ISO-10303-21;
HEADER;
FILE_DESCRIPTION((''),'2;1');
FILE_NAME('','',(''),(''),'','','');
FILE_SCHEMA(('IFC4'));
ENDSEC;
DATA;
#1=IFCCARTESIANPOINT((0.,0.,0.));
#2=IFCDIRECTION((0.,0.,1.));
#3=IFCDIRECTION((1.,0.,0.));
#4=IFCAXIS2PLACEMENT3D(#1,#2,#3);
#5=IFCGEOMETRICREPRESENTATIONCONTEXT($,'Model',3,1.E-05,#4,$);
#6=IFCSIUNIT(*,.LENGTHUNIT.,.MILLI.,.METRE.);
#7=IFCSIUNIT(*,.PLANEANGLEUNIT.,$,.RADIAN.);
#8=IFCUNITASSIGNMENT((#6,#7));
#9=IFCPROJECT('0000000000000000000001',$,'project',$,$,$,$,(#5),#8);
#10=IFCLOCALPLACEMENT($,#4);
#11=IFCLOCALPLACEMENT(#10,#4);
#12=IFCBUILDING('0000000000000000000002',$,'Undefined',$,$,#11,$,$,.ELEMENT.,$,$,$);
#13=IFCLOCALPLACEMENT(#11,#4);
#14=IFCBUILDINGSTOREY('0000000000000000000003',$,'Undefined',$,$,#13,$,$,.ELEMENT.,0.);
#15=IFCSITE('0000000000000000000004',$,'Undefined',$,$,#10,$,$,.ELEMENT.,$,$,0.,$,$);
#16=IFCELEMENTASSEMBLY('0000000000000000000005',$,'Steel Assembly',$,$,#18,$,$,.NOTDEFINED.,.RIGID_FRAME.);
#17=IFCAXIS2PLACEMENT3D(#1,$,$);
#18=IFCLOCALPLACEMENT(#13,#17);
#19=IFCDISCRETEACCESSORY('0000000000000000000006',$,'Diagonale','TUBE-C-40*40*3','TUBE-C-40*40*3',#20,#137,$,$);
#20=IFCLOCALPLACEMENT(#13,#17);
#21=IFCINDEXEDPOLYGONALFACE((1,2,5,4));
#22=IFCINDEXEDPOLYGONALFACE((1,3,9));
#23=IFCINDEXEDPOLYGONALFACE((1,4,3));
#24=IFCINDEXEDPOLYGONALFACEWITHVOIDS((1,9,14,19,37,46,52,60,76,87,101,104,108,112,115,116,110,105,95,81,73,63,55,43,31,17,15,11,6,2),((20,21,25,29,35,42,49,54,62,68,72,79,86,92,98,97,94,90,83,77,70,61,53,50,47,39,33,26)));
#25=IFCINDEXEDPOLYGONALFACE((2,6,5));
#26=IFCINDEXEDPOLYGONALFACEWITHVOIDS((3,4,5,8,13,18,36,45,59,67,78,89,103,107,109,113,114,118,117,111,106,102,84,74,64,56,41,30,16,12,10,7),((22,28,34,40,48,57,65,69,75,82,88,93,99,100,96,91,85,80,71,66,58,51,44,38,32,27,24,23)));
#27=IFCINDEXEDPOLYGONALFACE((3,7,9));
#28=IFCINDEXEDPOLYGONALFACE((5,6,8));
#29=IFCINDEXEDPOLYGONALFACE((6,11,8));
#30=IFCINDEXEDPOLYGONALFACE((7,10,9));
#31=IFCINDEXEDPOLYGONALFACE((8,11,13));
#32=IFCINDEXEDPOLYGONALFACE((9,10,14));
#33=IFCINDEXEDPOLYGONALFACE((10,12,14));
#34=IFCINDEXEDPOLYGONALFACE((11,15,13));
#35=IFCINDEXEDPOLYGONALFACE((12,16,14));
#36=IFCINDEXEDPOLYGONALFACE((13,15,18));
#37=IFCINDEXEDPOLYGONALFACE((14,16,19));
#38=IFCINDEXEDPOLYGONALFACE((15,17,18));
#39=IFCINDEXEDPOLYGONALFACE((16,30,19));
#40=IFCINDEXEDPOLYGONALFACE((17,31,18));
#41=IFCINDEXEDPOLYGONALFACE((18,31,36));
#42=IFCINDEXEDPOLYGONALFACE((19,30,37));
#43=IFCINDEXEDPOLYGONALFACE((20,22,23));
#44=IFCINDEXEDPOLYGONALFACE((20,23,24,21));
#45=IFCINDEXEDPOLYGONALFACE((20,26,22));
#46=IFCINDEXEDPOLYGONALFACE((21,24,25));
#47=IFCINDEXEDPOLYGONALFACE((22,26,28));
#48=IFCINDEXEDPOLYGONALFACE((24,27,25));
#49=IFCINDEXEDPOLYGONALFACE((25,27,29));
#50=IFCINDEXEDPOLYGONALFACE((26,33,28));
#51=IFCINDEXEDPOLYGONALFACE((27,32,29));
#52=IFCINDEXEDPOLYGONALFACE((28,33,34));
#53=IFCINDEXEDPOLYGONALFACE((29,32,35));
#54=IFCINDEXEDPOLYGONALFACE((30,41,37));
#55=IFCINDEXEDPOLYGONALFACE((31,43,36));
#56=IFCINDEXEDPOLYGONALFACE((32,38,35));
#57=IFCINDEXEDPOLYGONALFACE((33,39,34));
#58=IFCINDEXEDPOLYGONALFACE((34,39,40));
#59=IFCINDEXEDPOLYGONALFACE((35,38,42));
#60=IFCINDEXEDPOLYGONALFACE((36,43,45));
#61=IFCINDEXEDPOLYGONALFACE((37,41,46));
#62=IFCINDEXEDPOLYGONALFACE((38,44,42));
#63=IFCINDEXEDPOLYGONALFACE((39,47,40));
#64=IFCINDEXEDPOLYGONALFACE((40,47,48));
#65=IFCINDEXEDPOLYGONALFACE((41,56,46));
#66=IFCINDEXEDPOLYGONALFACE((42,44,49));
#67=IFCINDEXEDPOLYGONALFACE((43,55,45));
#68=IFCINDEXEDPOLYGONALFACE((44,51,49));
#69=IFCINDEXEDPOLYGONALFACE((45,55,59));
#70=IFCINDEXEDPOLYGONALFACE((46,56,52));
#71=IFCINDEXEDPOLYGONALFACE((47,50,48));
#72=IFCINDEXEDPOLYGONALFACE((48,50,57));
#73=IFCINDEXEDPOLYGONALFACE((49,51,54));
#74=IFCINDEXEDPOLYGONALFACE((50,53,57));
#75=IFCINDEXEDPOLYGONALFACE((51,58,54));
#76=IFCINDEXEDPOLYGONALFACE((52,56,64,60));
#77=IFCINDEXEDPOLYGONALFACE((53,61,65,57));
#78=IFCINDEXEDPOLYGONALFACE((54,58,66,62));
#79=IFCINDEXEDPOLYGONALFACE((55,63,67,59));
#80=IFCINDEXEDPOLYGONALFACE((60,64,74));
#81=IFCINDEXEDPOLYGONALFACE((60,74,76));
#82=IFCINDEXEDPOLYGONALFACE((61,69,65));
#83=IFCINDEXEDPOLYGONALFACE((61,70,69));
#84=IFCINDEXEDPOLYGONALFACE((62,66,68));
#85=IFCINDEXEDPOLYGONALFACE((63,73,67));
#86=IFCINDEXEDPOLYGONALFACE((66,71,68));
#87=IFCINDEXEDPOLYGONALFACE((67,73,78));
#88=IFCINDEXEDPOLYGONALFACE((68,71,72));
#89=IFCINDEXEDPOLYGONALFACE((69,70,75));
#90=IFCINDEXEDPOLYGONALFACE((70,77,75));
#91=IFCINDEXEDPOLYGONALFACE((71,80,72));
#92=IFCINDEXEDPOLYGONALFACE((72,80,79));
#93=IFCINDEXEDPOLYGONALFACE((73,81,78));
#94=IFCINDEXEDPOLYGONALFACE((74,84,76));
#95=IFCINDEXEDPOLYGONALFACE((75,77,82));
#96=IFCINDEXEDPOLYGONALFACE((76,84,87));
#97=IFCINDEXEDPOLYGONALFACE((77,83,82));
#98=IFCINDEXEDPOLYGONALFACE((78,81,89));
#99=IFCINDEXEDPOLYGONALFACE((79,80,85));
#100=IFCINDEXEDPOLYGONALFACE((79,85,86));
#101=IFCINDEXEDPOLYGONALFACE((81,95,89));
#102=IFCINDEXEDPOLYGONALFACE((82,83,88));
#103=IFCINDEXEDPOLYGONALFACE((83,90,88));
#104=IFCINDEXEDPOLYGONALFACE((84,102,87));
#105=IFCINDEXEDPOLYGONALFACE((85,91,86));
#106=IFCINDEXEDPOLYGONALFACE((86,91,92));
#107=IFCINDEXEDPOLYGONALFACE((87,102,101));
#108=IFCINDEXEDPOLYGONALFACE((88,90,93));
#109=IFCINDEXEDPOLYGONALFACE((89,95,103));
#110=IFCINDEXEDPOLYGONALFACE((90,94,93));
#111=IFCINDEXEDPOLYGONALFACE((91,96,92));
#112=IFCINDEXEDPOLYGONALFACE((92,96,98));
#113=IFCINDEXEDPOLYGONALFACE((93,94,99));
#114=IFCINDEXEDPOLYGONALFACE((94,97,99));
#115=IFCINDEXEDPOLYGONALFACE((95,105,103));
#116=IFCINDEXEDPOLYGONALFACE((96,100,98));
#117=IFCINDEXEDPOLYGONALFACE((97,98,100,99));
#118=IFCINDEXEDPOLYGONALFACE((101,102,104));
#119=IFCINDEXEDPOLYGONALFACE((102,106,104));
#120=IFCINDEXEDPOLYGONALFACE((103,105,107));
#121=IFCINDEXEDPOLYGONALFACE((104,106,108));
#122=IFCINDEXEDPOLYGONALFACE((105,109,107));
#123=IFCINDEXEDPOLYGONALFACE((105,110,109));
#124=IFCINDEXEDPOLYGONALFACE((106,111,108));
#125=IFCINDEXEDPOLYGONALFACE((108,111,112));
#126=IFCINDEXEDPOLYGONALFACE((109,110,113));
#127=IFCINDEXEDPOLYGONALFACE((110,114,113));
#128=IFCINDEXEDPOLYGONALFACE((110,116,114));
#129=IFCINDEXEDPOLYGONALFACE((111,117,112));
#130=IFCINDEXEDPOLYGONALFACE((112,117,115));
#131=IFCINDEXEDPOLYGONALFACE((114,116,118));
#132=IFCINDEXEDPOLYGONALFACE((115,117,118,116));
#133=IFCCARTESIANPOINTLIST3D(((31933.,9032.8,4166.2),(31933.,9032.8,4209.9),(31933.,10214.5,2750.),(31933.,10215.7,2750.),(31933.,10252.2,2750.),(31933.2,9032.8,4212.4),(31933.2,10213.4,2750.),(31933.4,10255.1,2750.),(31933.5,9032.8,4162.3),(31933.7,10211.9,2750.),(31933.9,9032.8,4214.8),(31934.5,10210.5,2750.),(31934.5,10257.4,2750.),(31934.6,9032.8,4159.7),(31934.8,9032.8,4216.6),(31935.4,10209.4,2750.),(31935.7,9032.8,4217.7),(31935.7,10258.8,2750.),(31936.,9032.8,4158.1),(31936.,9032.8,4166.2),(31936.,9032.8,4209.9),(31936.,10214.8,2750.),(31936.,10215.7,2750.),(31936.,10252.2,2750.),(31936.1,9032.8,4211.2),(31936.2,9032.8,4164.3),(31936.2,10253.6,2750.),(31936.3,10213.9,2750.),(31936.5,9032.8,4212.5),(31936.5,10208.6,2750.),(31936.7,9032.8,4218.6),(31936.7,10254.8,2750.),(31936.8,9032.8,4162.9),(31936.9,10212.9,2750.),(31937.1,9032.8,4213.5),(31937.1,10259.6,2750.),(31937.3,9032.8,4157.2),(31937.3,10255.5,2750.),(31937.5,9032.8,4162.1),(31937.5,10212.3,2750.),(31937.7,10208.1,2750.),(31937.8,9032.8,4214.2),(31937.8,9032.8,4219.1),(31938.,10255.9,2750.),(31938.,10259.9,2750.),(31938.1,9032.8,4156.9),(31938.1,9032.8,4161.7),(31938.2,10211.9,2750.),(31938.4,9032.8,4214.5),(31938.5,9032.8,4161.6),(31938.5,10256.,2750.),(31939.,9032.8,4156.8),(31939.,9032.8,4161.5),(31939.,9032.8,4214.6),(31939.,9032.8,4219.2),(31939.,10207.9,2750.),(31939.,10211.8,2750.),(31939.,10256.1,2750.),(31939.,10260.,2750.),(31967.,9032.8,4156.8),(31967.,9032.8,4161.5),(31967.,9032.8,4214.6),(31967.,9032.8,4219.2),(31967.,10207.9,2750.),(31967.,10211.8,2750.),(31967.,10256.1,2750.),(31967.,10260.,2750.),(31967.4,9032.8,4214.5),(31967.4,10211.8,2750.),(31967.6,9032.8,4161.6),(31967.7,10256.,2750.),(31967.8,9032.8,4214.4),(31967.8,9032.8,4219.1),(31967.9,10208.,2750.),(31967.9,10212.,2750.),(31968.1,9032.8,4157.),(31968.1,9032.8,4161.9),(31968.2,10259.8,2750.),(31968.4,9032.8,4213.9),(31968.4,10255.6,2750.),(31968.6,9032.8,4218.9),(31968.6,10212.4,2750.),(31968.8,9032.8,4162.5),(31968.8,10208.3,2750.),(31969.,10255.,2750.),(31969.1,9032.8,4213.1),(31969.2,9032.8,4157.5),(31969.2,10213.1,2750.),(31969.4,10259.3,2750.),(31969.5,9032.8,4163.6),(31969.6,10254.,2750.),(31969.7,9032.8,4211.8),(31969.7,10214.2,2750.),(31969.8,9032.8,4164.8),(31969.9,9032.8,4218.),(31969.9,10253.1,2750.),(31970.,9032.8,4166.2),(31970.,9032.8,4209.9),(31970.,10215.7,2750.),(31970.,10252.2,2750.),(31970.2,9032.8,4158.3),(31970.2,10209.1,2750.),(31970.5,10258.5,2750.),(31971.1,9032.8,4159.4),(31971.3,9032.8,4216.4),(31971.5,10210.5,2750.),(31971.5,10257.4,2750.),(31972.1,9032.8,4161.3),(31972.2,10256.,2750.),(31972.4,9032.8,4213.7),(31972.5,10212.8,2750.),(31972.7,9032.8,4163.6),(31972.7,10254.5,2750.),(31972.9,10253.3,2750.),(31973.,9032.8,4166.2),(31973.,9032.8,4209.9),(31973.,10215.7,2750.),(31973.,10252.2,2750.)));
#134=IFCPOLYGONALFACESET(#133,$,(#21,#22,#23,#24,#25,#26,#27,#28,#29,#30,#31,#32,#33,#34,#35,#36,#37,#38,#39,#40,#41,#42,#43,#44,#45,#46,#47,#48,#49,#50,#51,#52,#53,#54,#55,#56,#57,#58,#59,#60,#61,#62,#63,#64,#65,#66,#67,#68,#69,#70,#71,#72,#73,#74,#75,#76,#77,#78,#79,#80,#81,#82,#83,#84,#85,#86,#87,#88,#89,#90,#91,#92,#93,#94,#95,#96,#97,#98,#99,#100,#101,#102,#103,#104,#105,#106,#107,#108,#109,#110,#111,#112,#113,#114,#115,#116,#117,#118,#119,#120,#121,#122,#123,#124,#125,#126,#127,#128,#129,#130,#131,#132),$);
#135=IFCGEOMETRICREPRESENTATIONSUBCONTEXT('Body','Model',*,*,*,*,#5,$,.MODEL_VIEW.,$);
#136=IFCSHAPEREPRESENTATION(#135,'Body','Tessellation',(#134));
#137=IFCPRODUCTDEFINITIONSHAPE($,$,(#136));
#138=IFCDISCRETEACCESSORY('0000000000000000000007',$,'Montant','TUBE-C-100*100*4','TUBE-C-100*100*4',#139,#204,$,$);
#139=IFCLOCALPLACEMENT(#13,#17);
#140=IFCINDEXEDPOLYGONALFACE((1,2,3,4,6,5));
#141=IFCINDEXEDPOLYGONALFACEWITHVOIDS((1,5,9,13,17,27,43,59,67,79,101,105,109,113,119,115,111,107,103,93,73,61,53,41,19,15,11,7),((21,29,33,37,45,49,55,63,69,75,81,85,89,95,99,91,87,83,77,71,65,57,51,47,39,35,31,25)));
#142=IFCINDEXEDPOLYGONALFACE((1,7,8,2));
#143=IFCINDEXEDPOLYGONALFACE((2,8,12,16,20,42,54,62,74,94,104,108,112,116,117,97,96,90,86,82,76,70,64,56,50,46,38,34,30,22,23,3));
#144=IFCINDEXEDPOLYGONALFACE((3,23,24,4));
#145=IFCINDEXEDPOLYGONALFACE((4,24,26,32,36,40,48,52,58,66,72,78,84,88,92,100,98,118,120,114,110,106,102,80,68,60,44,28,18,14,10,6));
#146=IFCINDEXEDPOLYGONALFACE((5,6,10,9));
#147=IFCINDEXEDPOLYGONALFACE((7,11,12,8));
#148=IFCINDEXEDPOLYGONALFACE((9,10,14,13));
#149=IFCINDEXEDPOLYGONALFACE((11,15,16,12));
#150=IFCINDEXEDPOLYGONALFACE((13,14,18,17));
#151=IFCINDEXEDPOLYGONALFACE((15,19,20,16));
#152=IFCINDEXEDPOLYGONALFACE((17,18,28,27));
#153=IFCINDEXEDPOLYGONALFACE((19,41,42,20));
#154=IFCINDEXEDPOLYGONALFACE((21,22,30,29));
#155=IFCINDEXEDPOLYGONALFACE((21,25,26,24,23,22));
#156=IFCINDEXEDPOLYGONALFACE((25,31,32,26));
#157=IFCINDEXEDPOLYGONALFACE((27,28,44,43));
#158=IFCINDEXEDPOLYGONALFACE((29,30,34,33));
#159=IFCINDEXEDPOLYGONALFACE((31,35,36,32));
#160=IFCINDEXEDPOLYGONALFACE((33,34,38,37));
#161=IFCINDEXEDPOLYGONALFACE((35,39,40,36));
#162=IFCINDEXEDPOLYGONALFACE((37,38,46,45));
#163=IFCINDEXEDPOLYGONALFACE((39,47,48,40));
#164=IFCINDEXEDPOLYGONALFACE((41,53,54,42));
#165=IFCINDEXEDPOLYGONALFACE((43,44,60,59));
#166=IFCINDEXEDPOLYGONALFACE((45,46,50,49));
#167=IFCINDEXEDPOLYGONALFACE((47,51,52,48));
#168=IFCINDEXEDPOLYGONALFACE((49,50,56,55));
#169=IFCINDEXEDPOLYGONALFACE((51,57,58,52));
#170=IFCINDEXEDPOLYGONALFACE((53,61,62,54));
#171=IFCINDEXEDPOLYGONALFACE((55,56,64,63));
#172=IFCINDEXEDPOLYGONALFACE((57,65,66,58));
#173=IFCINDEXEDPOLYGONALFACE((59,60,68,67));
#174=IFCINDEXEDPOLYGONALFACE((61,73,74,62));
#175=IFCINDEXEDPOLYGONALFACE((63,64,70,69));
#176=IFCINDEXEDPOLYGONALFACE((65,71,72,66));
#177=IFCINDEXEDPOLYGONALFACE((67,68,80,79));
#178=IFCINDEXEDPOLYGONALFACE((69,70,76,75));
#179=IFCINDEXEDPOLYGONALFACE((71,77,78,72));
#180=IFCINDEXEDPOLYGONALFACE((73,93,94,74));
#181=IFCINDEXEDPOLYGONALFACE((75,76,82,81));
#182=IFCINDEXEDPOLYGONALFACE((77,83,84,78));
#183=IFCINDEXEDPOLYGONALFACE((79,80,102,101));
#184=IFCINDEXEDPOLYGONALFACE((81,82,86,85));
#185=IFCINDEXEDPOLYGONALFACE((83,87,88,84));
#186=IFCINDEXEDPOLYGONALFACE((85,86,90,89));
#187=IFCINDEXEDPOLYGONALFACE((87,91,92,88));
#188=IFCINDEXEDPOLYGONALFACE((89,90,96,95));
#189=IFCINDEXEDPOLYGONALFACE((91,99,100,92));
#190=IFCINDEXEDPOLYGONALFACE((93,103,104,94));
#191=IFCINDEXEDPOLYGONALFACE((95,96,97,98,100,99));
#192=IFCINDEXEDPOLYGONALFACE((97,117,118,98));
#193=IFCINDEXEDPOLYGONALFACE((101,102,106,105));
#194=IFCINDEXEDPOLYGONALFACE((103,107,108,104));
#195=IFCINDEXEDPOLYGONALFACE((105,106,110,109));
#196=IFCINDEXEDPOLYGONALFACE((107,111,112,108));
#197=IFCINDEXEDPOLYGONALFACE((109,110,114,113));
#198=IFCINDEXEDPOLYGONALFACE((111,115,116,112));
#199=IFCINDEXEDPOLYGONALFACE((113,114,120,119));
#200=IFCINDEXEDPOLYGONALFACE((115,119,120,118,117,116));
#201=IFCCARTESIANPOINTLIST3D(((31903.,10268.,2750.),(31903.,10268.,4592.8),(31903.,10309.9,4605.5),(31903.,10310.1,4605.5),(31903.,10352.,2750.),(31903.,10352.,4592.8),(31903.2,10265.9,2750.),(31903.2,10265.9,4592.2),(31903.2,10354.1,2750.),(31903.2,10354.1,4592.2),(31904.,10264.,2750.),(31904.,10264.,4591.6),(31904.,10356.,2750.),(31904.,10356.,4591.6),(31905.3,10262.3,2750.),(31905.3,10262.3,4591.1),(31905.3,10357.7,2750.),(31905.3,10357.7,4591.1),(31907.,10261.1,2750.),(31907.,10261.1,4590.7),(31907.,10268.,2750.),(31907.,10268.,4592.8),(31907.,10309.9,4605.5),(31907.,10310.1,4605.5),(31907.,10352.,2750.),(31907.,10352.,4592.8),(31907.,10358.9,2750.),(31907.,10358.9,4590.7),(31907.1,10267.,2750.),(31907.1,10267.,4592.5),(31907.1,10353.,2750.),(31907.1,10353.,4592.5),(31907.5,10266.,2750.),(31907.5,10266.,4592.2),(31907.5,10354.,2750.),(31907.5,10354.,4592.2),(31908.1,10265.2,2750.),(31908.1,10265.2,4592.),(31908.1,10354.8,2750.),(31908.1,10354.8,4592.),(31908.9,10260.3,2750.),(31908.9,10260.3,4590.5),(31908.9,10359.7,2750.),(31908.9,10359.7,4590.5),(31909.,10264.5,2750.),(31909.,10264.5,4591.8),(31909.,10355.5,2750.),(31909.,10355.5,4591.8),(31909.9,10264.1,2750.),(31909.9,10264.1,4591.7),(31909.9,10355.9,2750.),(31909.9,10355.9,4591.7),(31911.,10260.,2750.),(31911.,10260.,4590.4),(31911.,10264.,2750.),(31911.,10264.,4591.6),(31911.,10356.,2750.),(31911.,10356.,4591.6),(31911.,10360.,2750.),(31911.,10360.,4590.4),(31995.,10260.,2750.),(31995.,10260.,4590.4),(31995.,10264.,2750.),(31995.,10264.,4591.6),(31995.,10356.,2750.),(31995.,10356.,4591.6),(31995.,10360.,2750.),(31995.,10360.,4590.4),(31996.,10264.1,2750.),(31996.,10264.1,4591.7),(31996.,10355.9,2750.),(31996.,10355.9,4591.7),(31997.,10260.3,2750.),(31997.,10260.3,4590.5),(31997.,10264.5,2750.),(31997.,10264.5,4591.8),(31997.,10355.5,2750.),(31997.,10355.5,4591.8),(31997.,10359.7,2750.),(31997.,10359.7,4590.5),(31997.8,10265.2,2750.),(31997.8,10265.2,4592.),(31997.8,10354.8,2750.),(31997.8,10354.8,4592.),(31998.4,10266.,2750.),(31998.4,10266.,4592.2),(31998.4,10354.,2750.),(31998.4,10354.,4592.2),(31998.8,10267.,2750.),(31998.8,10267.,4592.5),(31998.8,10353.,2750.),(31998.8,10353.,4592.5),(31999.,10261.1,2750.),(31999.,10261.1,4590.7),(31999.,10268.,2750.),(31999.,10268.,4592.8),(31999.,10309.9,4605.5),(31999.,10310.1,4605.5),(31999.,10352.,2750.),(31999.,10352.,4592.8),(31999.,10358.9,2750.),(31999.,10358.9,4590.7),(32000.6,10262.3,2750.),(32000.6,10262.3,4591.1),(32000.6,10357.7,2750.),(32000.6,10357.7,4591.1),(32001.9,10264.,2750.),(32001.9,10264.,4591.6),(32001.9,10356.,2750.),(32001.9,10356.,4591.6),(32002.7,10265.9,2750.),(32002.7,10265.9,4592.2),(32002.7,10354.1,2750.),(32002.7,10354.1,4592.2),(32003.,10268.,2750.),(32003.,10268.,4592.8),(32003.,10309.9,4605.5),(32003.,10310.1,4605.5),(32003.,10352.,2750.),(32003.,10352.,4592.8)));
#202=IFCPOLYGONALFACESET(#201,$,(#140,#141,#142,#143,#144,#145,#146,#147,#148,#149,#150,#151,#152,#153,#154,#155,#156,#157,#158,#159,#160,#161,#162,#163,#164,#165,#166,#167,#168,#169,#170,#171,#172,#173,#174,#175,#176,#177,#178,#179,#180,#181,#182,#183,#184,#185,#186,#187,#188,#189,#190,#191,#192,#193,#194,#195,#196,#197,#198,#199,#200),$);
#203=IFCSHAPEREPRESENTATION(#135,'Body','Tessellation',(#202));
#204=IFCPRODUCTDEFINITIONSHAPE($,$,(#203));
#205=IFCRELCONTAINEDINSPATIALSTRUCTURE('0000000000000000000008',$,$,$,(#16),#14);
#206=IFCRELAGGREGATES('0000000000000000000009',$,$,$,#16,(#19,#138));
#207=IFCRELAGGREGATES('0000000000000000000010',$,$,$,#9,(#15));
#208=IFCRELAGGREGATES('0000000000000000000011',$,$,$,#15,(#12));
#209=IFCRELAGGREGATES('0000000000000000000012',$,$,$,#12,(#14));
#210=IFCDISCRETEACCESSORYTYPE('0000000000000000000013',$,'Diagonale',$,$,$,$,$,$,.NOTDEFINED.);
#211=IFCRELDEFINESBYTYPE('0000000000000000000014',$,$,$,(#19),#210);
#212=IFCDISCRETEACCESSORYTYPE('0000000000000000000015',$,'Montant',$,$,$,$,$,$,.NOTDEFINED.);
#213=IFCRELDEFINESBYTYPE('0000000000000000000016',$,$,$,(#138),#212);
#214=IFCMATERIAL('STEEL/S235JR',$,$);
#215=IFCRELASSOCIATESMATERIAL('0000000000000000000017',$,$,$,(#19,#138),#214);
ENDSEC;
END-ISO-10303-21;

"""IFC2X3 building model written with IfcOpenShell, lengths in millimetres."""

from ifc_helpers import new_model, si_unit, frame, origin_with_axes, origin_2d_with_axis, place, context, subcontext, project, spatial, hollow_rectangle, extrude, clip, halfspace, material, type_object, element, aggregate, save


model = new_model("IFC2X3")

# Units and contexts
model_context = context("Model", 3, precision=1e-05, world=origin_with_axes())
body_context = subcontext(model_context, "Body", "Model", "MODEL_VIEW")
ifc_project = project(units=[si_unit("LENGTHUNIT", "METRE", prefix="MILLI"), si_unit("PLANEANGLEUNIT", "RADIAN")], contexts=[model_context])

# Site, building, storey
site_placement = place(None, origin_with_axes())
site = spatial("IfcSite", under=ifc_project, at=site_placement, Name="Undefined", CompositionType="ELEMENT", RefElevation=0.0)
building_placement = place(site_placement, origin_with_axes())
building = spatial("IfcBuilding", under=site, at=building_placement, Name="Undefined", CompositionType="ELEMENT")
storey_placement = place(building_placement, origin_with_axes())
storey = spatial("IfcBuildingStorey", under=building, at=storey_placement, Name="Undefined", CompositionType="ELEMENT", Elevation=0.0)

# Element assembly, discrete accessories
ifc_material_1 = material(Name="STEEL/S235JR")
assembly_1_placement = place(storey_placement, origin_with_axes())
assembly_1 = element("IfcElementAssembly", 1, at=assembly_1_placement, inside=storey, Name="Steel Assembly", AssemblyPlace="NOTDEFINED", PredefinedType="RIGID_FRAME")
discrete_accessory_type_1 = type_object("IfcDiscreteAccessoryType", Name="Diagonale")
discrete_accessory_1_placement = place(assembly_1_placement, frame((31953.0, 10244.6, 2737.2), z_axis=(0.0, 0.767483, 0.64107), x_axis=(0.0, -0.64107, 0.767483)))
discrete_accessory_1 = element("IfcDiscreteAccessory", 2, at=discrete_accessory_1_placement, type_object=discrete_accessory_type_1, material=ifc_material_1, Name="Diagonale", Description="TUBE-C-40*40*3", ObjectType="TUBE-C-40*40*3", context=body_context, shape_type="Clipping", body=[
    clip(clip(extrude(hollow_rectangle(XDim=40.0, YDim=40.0, WallThickness=3.0, InnerFilletRadius=3.0, OuterFilletRadius=6.0, at=origin_2d_with_axis()), frame((1931.5, 0.0, 0.0), z_axis=(-1.0, 0.0, 0.0), x_axis=(0.0, -1.0, 0.0)), (0.0, 0.0, 1.0), 1955.8), halfspace(frame((1843.1, 0.0, -39.5), z_axis=(0.64107, 0.0, -0.767483), x_axis=(0.767483, 0.0, 0.64107)), False)), halfspace(frame((17.2, 0.0, -0.6), z_axis=(-0.767483, 0.0, -0.64107), x_axis=(0.64107, 0.0, -0.767483)), False)),
])
discrete_accessory_type_2 = type_object("IfcDiscreteAccessoryType", Name="Montant")
discrete_accessory_2_placement = place(assembly_1_placement, frame((31953.0, 10310.0, 4605.5), z_axis=(-1.0, 0.0, 0.0), x_axis=(0.0, 0.0, -1.0)))
discrete_accessory_2 = element("IfcDiscreteAccessory", 3, at=discrete_accessory_2_placement, type_object=discrete_accessory_type_2, material=ifc_material_1, Name="Montant", Description="TUBE-C-100*100*4", ObjectType="TUBE-C-100*100*4", context=body_context, shape_type="Clipping", body=[
    clip(clip(extrude(hollow_rectangle(XDim=100.0, YDim=100.0, WallThickness=4.0, InnerFilletRadius=4.0, OuterFilletRadius=8.0, at=origin_2d_with_axis()), frame((1855.5, 0.0, 0.0), z_axis=(-1.0, 0.0, 0.0), x_axis=(0.0, -1.0, 0.0)), (0.0, 0.0, 1.0), 1855.5), halfspace(frame((-15.1, -50.0, -50.0), z_axis=(-0.957179, 0.289497, 0.0), x_axis=(0.289497, 0.957179, 0.0)), False)), halfspace(frame((-15.1, 50.0, -50.0), z_axis=(-0.957179, -0.289497, 0.0), x_axis=(0.0, 0.0, 1.0)), False)),
])
aggregate(assembly_1, [discrete_accessory_1, discrete_accessory_2])

save(model, "model.ifc")
